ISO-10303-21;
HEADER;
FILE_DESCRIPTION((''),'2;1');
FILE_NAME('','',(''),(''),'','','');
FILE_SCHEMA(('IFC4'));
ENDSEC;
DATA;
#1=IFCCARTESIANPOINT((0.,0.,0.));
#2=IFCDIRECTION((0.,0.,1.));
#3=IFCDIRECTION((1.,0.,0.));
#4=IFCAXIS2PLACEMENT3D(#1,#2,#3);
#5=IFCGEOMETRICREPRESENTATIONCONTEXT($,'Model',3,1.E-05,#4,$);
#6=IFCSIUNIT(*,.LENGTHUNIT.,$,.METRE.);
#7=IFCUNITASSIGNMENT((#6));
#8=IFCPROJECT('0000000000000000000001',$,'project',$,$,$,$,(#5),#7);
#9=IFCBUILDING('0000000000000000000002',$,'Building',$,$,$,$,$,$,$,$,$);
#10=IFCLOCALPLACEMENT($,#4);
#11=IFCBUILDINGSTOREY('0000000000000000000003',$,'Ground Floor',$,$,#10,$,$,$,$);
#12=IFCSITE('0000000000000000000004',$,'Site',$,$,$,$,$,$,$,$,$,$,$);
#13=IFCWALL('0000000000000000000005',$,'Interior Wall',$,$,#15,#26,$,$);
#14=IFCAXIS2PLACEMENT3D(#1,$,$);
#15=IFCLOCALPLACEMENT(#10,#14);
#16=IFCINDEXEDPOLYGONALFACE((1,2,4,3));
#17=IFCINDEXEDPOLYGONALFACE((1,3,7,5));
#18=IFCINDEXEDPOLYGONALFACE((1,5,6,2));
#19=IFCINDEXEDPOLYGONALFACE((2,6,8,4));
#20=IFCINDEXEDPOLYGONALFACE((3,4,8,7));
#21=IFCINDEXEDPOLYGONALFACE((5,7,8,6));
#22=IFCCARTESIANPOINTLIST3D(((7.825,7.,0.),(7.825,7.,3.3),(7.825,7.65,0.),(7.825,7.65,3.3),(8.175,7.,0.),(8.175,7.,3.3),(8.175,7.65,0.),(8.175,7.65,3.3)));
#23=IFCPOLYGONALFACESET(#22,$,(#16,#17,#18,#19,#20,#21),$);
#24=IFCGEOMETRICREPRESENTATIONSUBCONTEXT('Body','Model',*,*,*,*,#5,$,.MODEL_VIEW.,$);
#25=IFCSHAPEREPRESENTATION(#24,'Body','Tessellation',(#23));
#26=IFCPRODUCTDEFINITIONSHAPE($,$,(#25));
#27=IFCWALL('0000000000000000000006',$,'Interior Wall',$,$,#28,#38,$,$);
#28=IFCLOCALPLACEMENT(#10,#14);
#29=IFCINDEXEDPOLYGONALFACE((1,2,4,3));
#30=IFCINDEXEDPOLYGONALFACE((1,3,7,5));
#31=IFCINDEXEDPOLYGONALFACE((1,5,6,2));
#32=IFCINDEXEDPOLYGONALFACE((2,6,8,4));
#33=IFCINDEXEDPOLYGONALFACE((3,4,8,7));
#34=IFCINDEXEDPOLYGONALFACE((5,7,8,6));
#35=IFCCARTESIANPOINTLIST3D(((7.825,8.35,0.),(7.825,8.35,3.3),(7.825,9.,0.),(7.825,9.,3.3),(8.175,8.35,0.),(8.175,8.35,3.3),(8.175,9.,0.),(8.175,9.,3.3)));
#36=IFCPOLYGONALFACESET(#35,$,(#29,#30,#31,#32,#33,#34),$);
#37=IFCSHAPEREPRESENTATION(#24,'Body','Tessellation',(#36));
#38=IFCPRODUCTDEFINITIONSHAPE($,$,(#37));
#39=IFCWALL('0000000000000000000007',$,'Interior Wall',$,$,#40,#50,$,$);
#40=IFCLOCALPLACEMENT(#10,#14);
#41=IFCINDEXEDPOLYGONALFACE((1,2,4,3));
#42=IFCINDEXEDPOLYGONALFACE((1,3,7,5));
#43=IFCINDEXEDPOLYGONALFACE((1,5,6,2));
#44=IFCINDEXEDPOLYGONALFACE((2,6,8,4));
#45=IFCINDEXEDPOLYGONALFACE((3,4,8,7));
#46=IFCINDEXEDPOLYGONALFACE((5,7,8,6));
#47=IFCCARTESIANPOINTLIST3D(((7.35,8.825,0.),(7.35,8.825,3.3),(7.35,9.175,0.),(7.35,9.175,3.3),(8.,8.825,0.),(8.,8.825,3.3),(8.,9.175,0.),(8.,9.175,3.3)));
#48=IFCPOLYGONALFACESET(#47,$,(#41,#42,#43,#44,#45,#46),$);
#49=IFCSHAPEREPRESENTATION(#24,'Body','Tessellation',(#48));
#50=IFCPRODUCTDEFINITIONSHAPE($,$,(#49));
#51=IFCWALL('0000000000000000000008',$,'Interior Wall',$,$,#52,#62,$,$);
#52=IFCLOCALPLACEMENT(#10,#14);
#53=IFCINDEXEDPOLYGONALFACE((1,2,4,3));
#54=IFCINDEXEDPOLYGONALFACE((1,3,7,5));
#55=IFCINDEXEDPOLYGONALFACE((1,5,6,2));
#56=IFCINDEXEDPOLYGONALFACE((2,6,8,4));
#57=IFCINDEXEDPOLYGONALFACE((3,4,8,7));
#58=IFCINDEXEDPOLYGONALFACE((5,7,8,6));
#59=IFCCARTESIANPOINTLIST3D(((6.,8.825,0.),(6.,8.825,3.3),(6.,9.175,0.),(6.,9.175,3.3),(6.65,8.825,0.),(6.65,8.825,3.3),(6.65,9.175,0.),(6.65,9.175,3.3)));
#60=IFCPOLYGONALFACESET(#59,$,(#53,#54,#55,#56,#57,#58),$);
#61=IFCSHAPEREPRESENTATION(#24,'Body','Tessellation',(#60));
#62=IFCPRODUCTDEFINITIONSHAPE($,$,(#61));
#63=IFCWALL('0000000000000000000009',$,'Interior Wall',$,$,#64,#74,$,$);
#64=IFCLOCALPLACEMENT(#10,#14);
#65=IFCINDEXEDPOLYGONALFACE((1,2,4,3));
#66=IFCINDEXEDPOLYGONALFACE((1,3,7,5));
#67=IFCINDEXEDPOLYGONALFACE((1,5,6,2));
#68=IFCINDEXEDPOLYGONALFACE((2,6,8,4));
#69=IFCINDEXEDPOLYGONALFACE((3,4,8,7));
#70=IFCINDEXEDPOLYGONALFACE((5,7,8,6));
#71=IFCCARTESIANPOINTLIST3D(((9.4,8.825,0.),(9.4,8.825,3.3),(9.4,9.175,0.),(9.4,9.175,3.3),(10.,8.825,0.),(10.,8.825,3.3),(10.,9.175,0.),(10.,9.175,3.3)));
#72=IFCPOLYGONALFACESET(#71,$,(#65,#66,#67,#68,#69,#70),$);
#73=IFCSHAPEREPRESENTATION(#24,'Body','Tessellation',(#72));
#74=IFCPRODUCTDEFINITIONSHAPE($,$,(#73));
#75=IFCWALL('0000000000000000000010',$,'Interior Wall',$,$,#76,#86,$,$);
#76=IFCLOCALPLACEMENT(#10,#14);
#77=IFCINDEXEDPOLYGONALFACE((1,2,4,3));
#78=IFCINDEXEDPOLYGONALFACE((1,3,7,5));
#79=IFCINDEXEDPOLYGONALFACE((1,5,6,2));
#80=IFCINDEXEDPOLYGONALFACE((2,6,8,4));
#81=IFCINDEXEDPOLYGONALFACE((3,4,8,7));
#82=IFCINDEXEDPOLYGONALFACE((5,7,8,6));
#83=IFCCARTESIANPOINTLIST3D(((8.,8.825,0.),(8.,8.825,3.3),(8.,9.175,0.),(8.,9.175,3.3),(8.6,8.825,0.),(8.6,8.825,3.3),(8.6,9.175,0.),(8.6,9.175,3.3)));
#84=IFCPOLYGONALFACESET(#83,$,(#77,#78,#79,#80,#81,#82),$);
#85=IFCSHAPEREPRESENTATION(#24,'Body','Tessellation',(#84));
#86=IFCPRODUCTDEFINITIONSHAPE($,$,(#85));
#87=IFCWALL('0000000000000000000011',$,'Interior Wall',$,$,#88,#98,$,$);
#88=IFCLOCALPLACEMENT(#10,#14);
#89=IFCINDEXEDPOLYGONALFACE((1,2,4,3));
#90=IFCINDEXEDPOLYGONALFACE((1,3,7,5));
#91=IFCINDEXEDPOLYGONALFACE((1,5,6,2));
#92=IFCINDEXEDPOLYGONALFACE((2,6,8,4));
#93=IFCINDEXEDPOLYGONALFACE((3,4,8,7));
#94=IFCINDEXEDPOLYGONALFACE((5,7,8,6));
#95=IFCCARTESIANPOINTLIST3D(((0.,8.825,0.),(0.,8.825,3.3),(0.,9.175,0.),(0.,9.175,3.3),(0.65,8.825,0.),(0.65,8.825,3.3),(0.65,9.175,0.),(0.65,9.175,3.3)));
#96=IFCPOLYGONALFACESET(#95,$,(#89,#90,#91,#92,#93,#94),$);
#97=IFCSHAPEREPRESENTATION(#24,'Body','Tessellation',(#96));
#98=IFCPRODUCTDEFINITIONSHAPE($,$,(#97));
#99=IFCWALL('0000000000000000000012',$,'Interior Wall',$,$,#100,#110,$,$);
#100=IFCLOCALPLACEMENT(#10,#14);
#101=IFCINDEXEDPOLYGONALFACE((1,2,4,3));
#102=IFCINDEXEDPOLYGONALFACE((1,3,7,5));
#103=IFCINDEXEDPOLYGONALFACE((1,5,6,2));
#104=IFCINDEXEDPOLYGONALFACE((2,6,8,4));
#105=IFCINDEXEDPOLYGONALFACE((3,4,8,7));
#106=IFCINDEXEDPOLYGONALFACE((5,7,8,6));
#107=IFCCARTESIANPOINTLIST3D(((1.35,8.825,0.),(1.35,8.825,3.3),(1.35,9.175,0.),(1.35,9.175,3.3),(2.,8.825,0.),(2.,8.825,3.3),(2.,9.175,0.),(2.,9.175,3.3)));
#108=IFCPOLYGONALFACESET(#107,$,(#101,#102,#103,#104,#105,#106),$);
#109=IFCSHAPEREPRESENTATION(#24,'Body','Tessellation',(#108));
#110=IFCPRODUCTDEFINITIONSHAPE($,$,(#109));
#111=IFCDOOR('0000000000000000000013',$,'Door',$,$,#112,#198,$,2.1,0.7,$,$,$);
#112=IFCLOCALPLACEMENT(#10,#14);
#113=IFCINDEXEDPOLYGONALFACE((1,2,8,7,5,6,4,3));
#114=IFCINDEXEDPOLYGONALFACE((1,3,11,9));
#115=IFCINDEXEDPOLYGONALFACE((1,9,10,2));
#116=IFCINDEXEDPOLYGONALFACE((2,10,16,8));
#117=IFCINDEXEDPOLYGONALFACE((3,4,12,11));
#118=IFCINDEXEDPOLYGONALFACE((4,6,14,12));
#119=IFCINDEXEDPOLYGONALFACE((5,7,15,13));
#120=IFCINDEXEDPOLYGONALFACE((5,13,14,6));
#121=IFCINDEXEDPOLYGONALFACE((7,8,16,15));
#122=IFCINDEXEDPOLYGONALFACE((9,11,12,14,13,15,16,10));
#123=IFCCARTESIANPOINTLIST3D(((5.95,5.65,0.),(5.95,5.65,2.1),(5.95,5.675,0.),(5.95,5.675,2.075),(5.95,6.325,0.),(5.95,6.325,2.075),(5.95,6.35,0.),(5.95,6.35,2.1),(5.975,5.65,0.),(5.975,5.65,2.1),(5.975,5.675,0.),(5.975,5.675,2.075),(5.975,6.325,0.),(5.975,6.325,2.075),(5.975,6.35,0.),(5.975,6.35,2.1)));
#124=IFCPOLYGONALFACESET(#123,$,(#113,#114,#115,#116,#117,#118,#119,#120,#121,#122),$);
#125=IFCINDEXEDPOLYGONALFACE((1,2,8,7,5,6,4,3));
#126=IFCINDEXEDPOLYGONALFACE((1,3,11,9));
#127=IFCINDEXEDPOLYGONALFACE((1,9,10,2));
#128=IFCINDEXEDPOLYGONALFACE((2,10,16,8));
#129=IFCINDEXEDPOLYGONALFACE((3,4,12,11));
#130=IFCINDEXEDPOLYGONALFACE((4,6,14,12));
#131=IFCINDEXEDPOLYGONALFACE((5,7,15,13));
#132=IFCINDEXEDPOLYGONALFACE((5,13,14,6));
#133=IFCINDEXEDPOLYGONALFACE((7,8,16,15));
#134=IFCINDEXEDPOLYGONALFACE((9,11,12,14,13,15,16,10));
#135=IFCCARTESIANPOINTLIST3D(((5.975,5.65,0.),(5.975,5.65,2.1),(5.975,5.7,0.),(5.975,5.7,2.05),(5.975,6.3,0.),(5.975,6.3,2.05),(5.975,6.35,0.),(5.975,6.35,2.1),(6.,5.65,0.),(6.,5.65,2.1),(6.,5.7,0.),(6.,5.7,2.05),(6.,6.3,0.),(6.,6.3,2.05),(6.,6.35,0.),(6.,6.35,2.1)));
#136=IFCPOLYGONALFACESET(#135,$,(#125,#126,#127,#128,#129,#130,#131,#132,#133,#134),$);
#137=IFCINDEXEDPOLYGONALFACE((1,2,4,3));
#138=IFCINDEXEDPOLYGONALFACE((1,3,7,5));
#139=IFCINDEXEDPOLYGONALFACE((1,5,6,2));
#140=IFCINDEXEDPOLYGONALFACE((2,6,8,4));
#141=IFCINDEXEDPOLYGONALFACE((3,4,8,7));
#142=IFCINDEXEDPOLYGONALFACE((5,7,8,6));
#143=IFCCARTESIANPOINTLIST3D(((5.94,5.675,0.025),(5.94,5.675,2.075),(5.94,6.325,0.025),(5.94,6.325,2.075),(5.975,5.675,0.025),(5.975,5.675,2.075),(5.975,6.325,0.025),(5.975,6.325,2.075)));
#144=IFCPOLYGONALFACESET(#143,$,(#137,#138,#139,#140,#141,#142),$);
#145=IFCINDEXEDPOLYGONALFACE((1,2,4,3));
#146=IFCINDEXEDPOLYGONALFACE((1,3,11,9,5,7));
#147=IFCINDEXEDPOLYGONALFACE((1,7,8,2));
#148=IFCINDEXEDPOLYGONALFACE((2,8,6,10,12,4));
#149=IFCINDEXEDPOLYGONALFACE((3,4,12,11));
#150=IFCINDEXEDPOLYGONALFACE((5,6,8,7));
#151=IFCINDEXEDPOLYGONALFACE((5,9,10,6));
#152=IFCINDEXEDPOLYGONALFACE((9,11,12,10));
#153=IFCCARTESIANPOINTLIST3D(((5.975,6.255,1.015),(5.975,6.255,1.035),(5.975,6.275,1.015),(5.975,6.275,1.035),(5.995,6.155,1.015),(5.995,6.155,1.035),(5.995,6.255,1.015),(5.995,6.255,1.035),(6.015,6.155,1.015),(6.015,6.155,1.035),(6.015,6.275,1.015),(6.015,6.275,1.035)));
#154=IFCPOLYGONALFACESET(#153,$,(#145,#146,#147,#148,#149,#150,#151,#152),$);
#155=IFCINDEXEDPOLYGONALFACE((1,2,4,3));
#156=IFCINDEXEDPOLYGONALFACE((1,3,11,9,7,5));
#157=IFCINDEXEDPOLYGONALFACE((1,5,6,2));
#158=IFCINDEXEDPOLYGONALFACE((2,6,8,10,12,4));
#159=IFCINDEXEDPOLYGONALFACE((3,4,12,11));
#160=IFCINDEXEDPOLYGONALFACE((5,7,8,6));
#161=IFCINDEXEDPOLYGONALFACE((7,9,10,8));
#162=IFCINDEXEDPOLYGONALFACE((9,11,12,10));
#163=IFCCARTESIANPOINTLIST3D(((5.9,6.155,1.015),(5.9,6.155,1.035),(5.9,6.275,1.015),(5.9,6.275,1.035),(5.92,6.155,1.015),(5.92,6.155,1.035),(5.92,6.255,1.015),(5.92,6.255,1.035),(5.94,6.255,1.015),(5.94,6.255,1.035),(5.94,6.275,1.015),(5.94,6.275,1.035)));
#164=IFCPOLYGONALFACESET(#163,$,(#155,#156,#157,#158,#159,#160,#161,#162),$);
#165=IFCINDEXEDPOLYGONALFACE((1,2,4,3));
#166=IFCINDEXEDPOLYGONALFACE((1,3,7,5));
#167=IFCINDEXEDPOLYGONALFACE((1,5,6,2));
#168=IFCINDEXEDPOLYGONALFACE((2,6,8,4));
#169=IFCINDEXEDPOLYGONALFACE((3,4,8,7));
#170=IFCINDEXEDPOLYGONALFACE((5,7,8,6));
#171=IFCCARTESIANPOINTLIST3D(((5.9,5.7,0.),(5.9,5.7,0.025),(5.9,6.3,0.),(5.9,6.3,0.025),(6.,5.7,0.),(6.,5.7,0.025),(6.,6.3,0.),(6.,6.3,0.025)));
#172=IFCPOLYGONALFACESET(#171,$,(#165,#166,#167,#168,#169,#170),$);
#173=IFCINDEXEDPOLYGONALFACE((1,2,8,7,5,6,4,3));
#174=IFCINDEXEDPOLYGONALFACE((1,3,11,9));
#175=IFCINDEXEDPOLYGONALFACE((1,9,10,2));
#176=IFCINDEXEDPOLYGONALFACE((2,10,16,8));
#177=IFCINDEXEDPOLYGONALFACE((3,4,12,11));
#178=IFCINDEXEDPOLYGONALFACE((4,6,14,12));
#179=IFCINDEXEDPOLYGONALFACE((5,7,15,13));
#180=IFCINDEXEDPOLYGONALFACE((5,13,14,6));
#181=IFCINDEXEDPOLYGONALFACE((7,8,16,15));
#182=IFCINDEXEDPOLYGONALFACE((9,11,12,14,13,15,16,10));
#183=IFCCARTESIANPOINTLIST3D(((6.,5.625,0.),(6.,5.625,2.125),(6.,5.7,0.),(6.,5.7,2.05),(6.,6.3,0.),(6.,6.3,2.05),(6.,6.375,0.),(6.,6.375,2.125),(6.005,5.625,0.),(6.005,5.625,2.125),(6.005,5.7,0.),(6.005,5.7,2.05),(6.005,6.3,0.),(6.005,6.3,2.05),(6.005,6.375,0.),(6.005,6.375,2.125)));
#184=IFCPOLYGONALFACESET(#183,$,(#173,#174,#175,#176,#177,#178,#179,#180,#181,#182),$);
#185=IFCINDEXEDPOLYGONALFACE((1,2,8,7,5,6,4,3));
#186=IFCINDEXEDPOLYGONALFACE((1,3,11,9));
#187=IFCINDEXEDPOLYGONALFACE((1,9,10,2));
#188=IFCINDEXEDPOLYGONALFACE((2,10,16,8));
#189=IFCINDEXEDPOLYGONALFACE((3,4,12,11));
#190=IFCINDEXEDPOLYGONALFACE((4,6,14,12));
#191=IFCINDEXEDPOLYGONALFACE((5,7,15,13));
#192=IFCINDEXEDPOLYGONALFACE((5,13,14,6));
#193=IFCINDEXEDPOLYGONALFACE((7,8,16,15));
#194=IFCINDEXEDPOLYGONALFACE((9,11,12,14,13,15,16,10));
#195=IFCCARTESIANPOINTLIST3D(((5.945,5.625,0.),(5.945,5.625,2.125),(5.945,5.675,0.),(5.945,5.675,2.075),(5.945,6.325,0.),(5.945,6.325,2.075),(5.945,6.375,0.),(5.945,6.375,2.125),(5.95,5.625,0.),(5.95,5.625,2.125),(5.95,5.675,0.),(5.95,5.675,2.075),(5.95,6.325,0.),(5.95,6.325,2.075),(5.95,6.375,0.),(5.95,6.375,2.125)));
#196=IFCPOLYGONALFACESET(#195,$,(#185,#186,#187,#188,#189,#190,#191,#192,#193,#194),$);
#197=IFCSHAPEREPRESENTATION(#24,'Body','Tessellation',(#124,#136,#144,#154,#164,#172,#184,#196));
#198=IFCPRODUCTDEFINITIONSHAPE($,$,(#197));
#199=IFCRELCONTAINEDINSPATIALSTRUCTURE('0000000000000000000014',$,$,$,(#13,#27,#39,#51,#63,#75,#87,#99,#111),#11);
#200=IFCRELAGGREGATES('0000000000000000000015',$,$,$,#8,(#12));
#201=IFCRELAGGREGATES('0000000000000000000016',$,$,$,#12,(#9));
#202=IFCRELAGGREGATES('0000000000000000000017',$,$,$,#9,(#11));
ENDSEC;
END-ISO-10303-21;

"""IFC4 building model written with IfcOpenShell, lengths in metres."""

from ifc_helpers import new_model, si_unit, frame, origin_with_axes, place, context, subcontext, project, spatial, line, indexed_curve, outline, extrude, element, save


model = new_model("IFC4")

# Units and contexts
model_context = context("Model", 3, precision=1e-05, world=origin_with_axes())
body_context = subcontext(model_context, "Body", "Model", "MODEL_VIEW")
ifc_project = project(units=[si_unit("LENGTHUNIT", "METRE")], contexts=[model_context])

# Site, building, storey
site = spatial("IfcSite", under=ifc_project, Name="Site")
building = spatial("IfcBuilding", under=site, Name="Building")
storey_placement = place(None, origin_with_axes())
storey = spatial("IfcBuildingStorey", under=building, at=storey_placement, Name="Ground Floor")

# Walls
for number, where, z_axis, x_axis, name in (
    (1, (8.0, 7.0, 0.0), (0.0, 0.0, 1.0), (0.0, 1.0, 0.0), "Interior Wall"),
    (2, (8.0, 8.35, 0.0), (0.0, 0.0, 1.0), (0.0, 1.0, 0.0), "Interior Wall"),
    (3, (8.0, 9.0, 0.0), (0.0, 0.0, 1.0), (-1.0, 0.0, 0.0), "Interior Wall"),
    (4, (6.65, 9.0, 0.0), (0.0, 0.0, 1.0), (-1.0, 0.0, 0.0), "Interior Wall"),
):
    element("IfcWall", number, at=place(storey_placement, frame(where, z_axis=z_axis, x_axis=x_axis)), inside=storey, Name=name, context=body_context, shape_type="SweptSolid", body=[
        extrude(outline(indexed_curve([(0.0, 0.0), (0.0, 0.35), (0.65, 0.35), (0.65, 0.0), (0.0, 0.0)], self_intersect=False)), frame((0.0, -0.175, 0.0), z_axis=(0.0, 0.0, 1.0), x_axis=(1.0, 0.0, 0.0)), (0.0, 0.0, 1.0), 3.3),
    ])
for number, where, z_axis, x_axis, name in (
    (5, (10.0, 9.0, 0.0), (0.0, 0.0, 1.0), (-1.0, 0.0, 0.0), "Interior Wall"),
    (6, (8.6, 9.0, 0.0), (0.0, 0.0, 1.0), (-1.0, 0.0, 0.0), "Interior Wall"),
):
    element("IfcWall", number, at=place(storey_placement, frame(where, z_axis=z_axis, x_axis=x_axis)), inside=storey, Name=name, context=body_context, shape_type="SweptSolid", body=[
        extrude(outline(indexed_curve([(0.0, 0.0), (0.0, 0.35), (0.6, 0.35), (0.6, 0.0), (0.0, 0.0)], self_intersect=False)), frame((0.0, -0.175, 0.0), z_axis=(0.0, 0.0, 1.0), x_axis=(1.0, 0.0, 0.0)), (0.0, 0.0, 1.0), 3.3),
    ])
wall_1_placement = place(storey_placement, frame((0.0, 9.0, 0.0), z_axis=(0.0, 0.0, 1.0), x_axis=(1.0, 0.0, 0.0)))
element("IfcWall", 7, at=wall_1_placement, inside=storey, Name="Interior Wall", context=body_context, shape_type="SweptSolid", body=[
    extrude(outline(indexed_curve([(0.0, 0.0), (0.0, 0.35), (0.65, 0.35), (0.65, 0.0), (0.0, 0.0)], self_intersect=False)), frame((0.0, -0.175, 0.0), z_axis=(0.0, 0.0, 1.0), x_axis=(1.0, 0.0, 0.0)), (0.0, 0.0, 1.0), 3.3),
])
wall_2_placement = place(storey_placement, frame((1.35, 9.0, 0.0), z_axis=(0.0, 0.0, 1.0), x_axis=(1.0, 0.0, 0.0)))
element("IfcWall", 8, at=wall_2_placement, inside=storey, Name="Interior Wall", context=body_context, shape_type="SweptSolid", body=[
    extrude(outline(indexed_curve([(0.0, 0.0), (0.0, 0.35), (0.65, 0.35), (0.65, 0.0), (0.0, 0.0)], self_intersect=False)), frame((0.0, -0.175, 0.0), z_axis=(0.0, 0.0, 1.0), x_axis=(1.0, 0.0, 0.0)), (0.0, 0.0, 1.0), 3.3),
])

# Door
door_1_placement = place(storey_placement, frame((6.0, 5.65, 0.0), z_axis=(0.0, 0.0, 1.0), x_axis=(0.0, 1.0, 0.0)))
element("IfcDoor", 9, at=door_1_placement, inside=storey, Name="Door", OverallHeight=2.1, OverallWidth=0.7, context=body_context, shape_type="SweptSolid", body=[
    extrude(outline(indexed_curve([(0.0, 0.0), (0.0, 2.1), (0.7, 2.1), (0.7, 0.0), (0.675, 0.0), (0.675, 2.075), (0.025, 2.075), (0.025, 0.0)], segments=[line(1, 2, 3, 4, 5, 6, 7, 8, 1)])), frame((0.0, 0.025, 0.0), z_axis=(0.0, -1.0, 0.0), x_axis=(1.0, 0.0, 0.0)), (0.0, 0.0, -1.0), 0.025),
    extrude(outline(indexed_curve([(0.0, 0.0), (0.0, 2.1), (0.7, 2.1), (0.7, 0.0), (0.65, 0.0), (0.65, 2.05), (0.05, 2.05), (0.05, 0.0)], segments=[line(1, 2, 3, 4, 5, 6, 7, 8, 1)])), frame((0.0, 0.0, 0.0), z_axis=(0.0, -1.0, 0.0), x_axis=(1.0, 0.0, 0.0)), (0.0, 0.0, -1.0), 0.025),
    extrude(outline(indexed_curve([(0.0, 0.0), (0.65, 0.0), (0.65, 0.035), (0.0, 0.035)], segments=[line(1, 2, 3, 4, 1)])), frame((0.025, 0.025, 0.025), z_axis=(0.0, 0.0, 1.0), x_axis=(1.0, 0.0, 0.0)), (0.0, 0.0, 1.0), 2.05),
    extrude(outline(indexed_curve([(0.0, 0.0), (0.0, -0.04), (-0.12, -0.04), (-0.12, -0.02), (-0.02, -0.02), (-0.02, 0.0)], segments=[line(1, 2, 3, 4, 5, 6, 1)])), frame((0.625, 0.025, 1.015), z_axis=(0.0, 0.0, 1.0), x_axis=(1.0, 0.0, 0.0)), (0.0, 0.0, 1.0), 0.02),
    extrude(outline(indexed_curve([(0.0, 0.0), (0.0, 0.04), (-0.12, 0.04), (-0.12, 0.02), (-0.02, 0.02), (-0.02, 0.0)], segments=[line(1, 2, 3, 4, 5, 6, 1)])), frame((0.625, 0.06, 1.015), z_axis=(0.0, 0.0, 1.0), x_axis=(1.0, 0.0, 0.0)), (0.0, 0.0, 1.0), 0.02),
    extrude(outline(indexed_curve([(0.0, 0.0), (0.6, 0.0), (0.6, 0.1), (0.0, 0.1)], segments=[line(1, 2, 3, 4, 1)])), frame((0.05, 0.0, 0.0), z_axis=(0.0, 0.0, 1.0), x_axis=(1.0, 0.0, 0.0)), (0.0, 0.0, 1.0), 0.025),
    extrude(outline(indexed_curve([(0.0, 0.0), (0.0, 2.125), (0.75, 2.125), (0.75, 0.0), (0.675, 0.0), (0.675, 2.05), (0.075, 2.05), (0.075, 0.0)], segments=[line(1, 2, 3, 4, 5, 6, 7, 8, 1)])), frame((-0.025, -0.005, 0.0), z_axis=(0.0, -1.0, 0.0), x_axis=(1.0, 0.0, 0.0)), (0.0, 0.0, -1.0), 0.005),
    extrude(outline(indexed_curve([(0.0, 0.0), (0.0, 2.125), (0.75, 2.125), (0.75, 0.0), (0.7, 0.0), (0.7, 2.075), (0.05, 2.075), (0.05, 0.0)], segments=[line(1, 2, 3, 4, 5, 6, 7, 8, 1)])), frame((-0.025, 0.05, 0.0), z_axis=(0.0, -1.0, 0.0), x_axis=(1.0, 0.0, 0.0)), (0.0, 0.0, -1.0), 0.005),
])

save(model, "model.ifc")
